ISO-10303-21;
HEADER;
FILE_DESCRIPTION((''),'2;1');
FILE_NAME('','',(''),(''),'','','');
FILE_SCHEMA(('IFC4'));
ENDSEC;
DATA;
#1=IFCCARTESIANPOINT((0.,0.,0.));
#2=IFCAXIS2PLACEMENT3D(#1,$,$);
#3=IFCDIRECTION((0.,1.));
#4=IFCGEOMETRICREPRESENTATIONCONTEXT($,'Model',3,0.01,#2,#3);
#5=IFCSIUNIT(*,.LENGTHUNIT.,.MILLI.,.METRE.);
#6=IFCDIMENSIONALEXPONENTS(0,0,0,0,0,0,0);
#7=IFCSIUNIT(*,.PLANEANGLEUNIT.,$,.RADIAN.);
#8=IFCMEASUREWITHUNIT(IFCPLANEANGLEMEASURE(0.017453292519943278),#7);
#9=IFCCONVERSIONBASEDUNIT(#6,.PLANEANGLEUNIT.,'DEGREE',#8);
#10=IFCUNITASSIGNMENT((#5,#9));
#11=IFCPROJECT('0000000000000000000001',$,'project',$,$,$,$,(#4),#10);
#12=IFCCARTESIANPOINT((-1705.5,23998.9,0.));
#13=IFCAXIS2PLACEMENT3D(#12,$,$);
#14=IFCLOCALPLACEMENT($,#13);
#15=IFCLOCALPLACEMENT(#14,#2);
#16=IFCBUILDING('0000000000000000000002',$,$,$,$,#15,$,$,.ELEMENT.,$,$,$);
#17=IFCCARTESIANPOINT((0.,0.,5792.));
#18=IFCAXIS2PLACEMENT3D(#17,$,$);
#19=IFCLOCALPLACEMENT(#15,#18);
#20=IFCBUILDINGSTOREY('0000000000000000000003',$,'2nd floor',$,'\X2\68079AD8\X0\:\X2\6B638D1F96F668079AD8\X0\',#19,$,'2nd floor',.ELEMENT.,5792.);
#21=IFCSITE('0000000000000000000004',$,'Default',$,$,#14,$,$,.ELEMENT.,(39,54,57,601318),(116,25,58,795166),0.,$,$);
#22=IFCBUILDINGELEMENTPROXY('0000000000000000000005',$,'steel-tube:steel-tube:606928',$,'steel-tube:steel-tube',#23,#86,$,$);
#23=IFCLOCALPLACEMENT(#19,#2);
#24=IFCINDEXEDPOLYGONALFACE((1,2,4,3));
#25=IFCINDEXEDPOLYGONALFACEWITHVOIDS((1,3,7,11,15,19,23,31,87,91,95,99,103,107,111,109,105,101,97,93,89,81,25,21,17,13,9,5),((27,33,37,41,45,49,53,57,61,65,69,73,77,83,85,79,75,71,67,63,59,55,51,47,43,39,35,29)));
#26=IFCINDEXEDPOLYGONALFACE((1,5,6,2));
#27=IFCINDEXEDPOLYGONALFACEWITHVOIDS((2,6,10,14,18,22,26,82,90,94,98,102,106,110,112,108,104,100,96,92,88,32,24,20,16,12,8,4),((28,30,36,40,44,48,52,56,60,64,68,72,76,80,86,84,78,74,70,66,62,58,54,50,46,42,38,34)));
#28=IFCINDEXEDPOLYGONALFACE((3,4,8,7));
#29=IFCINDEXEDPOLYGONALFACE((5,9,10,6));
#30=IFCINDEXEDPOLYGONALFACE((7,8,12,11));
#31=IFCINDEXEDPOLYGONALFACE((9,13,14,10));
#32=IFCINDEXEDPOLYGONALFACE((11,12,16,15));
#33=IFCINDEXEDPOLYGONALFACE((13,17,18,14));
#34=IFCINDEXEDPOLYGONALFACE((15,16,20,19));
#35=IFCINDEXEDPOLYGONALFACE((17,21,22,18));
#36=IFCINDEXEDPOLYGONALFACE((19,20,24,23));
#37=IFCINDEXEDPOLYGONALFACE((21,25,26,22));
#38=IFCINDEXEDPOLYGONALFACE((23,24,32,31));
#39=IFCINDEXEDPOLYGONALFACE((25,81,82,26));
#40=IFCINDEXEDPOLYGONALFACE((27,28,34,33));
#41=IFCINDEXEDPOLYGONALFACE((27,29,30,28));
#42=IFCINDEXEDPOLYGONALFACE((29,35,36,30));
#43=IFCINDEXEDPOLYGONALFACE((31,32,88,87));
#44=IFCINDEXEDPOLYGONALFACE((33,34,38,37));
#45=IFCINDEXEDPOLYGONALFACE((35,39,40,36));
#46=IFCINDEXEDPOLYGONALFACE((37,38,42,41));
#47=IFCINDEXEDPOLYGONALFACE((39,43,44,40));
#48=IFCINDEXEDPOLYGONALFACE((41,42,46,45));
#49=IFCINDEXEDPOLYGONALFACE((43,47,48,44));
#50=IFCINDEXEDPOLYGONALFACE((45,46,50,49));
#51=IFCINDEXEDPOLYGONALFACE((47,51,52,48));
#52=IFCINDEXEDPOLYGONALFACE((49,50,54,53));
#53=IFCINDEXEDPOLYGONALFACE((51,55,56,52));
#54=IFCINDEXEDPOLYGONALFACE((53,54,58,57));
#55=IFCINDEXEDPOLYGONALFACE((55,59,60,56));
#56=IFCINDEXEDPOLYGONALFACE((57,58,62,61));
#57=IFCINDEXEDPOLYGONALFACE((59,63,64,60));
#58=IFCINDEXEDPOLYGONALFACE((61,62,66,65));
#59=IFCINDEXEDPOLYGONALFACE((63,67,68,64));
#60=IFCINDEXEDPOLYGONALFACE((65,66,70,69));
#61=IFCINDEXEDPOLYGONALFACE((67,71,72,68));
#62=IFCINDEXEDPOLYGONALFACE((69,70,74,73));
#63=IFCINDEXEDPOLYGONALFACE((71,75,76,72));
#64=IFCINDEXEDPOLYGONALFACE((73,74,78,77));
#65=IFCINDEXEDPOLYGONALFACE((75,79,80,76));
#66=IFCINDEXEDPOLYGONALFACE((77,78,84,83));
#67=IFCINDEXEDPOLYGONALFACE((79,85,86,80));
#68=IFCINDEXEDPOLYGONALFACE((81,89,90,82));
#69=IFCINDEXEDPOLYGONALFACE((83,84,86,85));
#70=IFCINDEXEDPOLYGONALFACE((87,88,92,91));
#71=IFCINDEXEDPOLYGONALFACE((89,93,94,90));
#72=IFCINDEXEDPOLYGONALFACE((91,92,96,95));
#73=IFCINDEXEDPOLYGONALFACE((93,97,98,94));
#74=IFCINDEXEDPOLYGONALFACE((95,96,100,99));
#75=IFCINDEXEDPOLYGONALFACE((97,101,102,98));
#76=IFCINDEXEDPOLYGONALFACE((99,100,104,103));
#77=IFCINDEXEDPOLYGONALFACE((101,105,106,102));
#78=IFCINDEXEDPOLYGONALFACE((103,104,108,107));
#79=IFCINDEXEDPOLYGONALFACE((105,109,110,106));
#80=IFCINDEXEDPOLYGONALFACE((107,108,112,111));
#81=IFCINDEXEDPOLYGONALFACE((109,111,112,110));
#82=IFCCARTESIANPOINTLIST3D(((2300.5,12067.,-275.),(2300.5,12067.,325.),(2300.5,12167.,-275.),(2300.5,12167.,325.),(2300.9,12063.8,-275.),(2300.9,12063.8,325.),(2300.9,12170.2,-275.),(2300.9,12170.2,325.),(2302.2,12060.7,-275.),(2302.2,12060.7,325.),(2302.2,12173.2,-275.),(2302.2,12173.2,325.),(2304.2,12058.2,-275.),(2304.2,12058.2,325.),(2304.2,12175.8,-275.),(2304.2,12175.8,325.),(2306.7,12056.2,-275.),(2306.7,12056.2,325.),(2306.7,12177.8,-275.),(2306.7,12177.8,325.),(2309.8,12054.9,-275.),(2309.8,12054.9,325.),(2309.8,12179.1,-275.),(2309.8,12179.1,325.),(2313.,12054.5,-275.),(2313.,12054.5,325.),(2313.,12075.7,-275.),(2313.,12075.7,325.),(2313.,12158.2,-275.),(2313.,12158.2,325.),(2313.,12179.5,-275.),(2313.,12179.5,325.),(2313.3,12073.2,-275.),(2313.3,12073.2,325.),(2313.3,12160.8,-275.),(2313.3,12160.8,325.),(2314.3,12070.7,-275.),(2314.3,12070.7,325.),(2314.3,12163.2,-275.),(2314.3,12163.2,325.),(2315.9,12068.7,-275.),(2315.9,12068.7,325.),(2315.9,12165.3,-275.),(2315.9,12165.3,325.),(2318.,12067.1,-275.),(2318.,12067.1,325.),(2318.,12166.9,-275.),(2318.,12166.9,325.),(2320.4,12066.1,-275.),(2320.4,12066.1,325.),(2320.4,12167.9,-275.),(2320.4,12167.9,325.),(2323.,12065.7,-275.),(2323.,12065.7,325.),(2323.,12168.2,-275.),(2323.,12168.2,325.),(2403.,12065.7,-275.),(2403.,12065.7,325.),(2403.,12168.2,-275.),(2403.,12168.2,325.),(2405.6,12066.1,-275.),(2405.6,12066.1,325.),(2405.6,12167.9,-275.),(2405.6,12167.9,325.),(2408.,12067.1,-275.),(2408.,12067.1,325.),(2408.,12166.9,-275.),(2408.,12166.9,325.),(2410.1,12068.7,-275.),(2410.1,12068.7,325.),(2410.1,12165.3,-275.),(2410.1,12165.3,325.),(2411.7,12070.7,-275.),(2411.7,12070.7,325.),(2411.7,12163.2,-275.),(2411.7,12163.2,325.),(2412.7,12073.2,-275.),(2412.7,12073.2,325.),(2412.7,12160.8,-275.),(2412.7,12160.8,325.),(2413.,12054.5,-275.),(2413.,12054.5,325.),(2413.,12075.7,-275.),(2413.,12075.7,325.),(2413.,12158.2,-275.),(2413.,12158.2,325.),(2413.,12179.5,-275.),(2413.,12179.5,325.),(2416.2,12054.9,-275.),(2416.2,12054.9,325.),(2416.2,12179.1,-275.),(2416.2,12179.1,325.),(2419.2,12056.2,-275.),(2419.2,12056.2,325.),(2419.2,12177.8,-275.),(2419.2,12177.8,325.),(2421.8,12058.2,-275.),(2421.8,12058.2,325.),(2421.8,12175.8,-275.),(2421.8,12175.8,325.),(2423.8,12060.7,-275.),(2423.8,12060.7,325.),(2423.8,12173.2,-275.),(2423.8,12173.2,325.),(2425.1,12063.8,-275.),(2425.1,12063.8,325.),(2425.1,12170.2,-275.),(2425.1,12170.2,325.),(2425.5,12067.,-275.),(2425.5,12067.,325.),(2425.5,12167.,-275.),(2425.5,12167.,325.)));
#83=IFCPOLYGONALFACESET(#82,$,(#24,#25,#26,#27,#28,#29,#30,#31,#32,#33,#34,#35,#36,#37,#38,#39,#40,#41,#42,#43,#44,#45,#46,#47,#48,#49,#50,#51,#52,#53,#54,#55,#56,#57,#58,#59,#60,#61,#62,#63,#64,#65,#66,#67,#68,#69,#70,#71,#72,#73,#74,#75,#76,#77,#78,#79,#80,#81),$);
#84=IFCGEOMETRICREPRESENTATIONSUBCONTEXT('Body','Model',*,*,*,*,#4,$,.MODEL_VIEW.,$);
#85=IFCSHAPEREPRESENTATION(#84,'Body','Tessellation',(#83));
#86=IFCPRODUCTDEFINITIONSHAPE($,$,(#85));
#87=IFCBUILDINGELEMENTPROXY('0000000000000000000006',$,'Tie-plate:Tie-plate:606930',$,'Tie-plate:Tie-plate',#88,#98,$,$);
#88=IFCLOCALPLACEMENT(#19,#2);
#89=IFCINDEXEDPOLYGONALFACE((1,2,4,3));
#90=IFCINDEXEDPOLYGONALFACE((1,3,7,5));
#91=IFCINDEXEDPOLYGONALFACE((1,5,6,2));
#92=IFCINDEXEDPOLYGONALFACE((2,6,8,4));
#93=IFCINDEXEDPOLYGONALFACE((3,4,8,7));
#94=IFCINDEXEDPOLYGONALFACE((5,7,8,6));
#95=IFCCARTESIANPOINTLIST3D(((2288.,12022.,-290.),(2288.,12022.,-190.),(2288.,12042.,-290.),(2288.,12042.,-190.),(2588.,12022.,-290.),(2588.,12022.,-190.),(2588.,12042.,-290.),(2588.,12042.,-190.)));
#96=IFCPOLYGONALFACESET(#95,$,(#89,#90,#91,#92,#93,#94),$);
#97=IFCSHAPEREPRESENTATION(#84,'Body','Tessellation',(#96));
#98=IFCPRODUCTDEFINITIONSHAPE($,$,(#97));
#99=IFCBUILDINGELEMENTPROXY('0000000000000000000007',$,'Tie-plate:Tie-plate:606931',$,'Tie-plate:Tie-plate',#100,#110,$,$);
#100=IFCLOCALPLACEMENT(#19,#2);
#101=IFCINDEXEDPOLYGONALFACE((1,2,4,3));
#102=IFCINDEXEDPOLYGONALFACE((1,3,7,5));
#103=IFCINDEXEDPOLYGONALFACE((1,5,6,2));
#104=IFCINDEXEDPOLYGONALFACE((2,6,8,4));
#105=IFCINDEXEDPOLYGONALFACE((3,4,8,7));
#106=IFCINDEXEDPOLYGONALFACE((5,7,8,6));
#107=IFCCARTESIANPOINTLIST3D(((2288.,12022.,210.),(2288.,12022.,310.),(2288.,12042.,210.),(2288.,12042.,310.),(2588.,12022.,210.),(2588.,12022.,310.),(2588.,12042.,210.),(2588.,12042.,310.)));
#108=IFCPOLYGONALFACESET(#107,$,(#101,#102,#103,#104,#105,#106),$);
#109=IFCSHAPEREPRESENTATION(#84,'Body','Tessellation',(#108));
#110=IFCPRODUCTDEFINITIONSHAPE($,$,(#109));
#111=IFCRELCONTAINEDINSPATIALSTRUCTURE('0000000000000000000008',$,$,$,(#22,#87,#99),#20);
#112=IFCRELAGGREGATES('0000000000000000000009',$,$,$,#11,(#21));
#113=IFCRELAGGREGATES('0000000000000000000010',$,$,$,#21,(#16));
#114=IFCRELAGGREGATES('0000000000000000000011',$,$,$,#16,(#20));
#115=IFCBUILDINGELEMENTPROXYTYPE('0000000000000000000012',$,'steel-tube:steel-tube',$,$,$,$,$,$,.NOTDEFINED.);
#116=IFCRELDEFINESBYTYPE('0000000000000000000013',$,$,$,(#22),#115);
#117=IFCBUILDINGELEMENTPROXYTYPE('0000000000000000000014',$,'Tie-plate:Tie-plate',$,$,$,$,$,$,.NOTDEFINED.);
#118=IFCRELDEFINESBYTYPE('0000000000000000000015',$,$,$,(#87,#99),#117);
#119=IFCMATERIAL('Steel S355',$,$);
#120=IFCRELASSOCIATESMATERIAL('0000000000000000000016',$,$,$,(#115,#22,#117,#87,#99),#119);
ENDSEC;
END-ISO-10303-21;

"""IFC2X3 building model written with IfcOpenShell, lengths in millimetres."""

from ifc_helpers import new_model, entity, si_unit, converted_unit, direction, frame, frame_2d, origin, place, context, subcontext, project, spatial, polyline, circle_curve, parameter, trimmed, segment, composite_curve, rectangle, outline, extrude, source, transform, mapped, material, type_object, type_shapes, element, save


model = new_model("IFC2X3")

# Units and contexts
model_context = context("Model", 3, precision=0.01, world=origin(), true_north=direction((0.0, 1.0)))
body_context = subcontext(model_context, "Body", "Model", "MODEL_VIEW")
ifc_project = project(units=[si_unit("LENGTHUNIT", "METRE", prefix="MILLI"), converted_unit("PLANEANGLEUNIT", "DEGREE", entity("IfcPlaneAngleMeasure", 0.017453292519943278), si_unit("PLANEANGLEUNIT", "RADIAN"), dimensions=[0, 0, 0, 0, 0, 0, 0])], contexts=[model_context])

# Site, building, storey
site_placement = place(None, frame((-1705.5, 23998.9, 0.0)))
site = spatial("IfcSite", under=ifc_project, at=site_placement, Name="Default", CompositionType="ELEMENT", RefLatitude=(39, 54, 57, 601318), RefLongitude=(116, 25, 58, 795166), RefElevation=0.0)
building_placement = place(site_placement, origin())
building = spatial("IfcBuilding", under=site, at=building_placement, CompositionType="ELEMENT")
storey_placement = place(building_placement, frame((0.0, 0.0, 5792.0)))
storey = spatial("IfcBuildingStorey", under=building, at=storey_placement, Name="2nd floor", ObjectType="标高:正负零标高", LongName="2nd floor", CompositionType="ELEMENT", Elevation=5792.0)

# Shared definitions
ifc_material_1 = material(Name="Steel S355")

# Building element proxies
building_element_proxy_type_1 = type_object("IfcBuildingElementProxyType", Name="steel-tube:steel-tube", PredefinedType="NOTDEFINED", material=ifc_material_1)
shared_shape_1 = source(origin(), body_context, "Body", "SweptSolid", [
    extrude(outline(composite_curve([segment(trimmed(circle_curve(frame_2d((50.0, -50.0), x_axis=(1.0, 0.0)), 12.5), [parameter(270.0)], [parameter(0.0)], True, "PARAMETER"), True, "CONTINUOUS"), segment(polyline([(62.5, -50.0), (62.5, 50.0)]), True, "CONTINUOUS"), segment(trimmed(circle_curve(frame_2d((50.0, 50.0), x_axis=(1.0, 0.0)), 12.5), [parameter(0.0)], [parameter(90.0)], True, "PARAMETER"), True, "CONTINUOUS"), segment(polyline([(50.0, 62.5), (-50.0, 62.5)]), True, "CONTINUOUS"), segment(trimmed(circle_curve(frame_2d((-50.0, 50.0), x_axis=(1.0, 0.0)), 12.5), [parameter(90.0)], [parameter(180.0)], True, "PARAMETER"), True, "CONTINUOUS"), segment(polyline([(-62.5, 50.0), (-62.5, -50.0)]), True, "CONTINUOUS"), segment(trimmed(circle_curve(frame_2d((-50.0, -50.0), x_axis=(1.0, 0.0)), 12.5), [parameter(180.0)], [parameter(270.0)], True, "PARAMETER"), True, "CONTINUOUS"), segment(polyline([(-50.0, -62.5), (50.0, -62.5)]), True, "CONTINUOUS")], self_intersect=False), holes=[composite_curve([segment(trimmed(circle_curve(frame_2d((-41.2, 40.0), x_axis=(1.0, 0.0)), 10.0), [parameter(90.0)], [parameter(180.0)], True, "PARAMETER"), False, "CONTINUOUS"), segment(polyline([(-41.3, 50.0), (41.2, 50.0)]), True, "CONTINUOUS"), segment(trimmed(circle_curve(frame_2d((41.2, 40.0), x_axis=(1.0, 0.0)), 10.0), [parameter(0.0)], [parameter(90.0)], True, "PARAMETER"), False, "CONTINUOUS"), segment(polyline([(51.2, 40.0), (51.2, -40.0)]), True, "CONTINUOUS"), segment(trimmed(circle_curve(frame_2d((41.2, -40.0), x_axis=(1.0, 0.0)), 10.0), [parameter(270.0)], [parameter(360.0)], True, "PARAMETER"), False, "CONTINUOUS"), segment(polyline([(41.2, -50.0), (-41.3, -50.0)]), True, "CONTINUOUS"), segment(trimmed(circle_curve(frame_2d((-41.3, -40.0), x_axis=(1.0, 0.0)), 10.0), [parameter(180.0)], [parameter(270.0)], True, "PARAMETER"), False, "CONTINUOUS"), segment(polyline([(-51.3, -40.0), (-51.3, 40.0)]), True, "CONTINUOUS")], self_intersect=False)]), frame((62.5, 62.5, -175.0)), (0.0, 0.0, 1.0), 600.0),
])
type_shapes(building_element_proxy_type_1, [shared_shape_1])
for number, where, z_axis, x_axis, name in (
    (1, (2300.5, 12179.5, -100.0), (0.0, 0.0, 1.0), (0.0, -1.0, 0.0), "steel-tube:steel-tube:606928"),
):
    element("IfcBuildingElementProxy", number, at=place(storey_placement, frame(where, z_axis=z_axis, x_axis=x_axis)), inside=storey, type_object=building_element_proxy_type_1, material=ifc_material_1, Name=name, ObjectType="steel-tube:steel-tube", context=body_context, shape_type="MappedRepresentation", body=[
        mapped(shared_shape_1, transform((0.0, 0.0, 0.0), scale=1.0)),
    ])
building_element_proxy_type_2 = type_object("IfcBuildingElementProxyType", Name="Tie-plate:Tie-plate", PredefinedType="NOTDEFINED", material=ifc_material_1)
shared_shape_2 = source(origin(), body_context, "Body", "SweptSolid", [
    extrude(rectangle(XDim=300.0, YDim=20.0, at=frame_2d((0.0, 0.0), x_axis=(1.0, 0.0))), frame((150.0, -10.0, 0.0), z_axis=(0.0, 0.0, 1.0), x_axis=(-1.0, 0.0, 0.0)), (0.0, 0.0, 1.0), 100.0),
])
type_shapes(building_element_proxy_type_2, [shared_shape_2])
for number, where, name in (
    (2, (2288.0, 12042.0, -290.0), "Tie-plate:Tie-plate:606930"),
    (3, (2288.0, 12042.0, 210.0), "Tie-plate:Tie-plate:606931"),
):
    element("IfcBuildingElementProxy", number, at=place(storey_placement, frame(where)), inside=storey, type_object=building_element_proxy_type_2, material=ifc_material_1, Name=name, ObjectType="Tie-plate:Tie-plate", context=body_context, shape_type="MappedRepresentation", body=[
        mapped(shared_shape_2, transform((0.0, 0.0, 0.0), scale=1.0)),
    ])

save(model, "model.ifc")
